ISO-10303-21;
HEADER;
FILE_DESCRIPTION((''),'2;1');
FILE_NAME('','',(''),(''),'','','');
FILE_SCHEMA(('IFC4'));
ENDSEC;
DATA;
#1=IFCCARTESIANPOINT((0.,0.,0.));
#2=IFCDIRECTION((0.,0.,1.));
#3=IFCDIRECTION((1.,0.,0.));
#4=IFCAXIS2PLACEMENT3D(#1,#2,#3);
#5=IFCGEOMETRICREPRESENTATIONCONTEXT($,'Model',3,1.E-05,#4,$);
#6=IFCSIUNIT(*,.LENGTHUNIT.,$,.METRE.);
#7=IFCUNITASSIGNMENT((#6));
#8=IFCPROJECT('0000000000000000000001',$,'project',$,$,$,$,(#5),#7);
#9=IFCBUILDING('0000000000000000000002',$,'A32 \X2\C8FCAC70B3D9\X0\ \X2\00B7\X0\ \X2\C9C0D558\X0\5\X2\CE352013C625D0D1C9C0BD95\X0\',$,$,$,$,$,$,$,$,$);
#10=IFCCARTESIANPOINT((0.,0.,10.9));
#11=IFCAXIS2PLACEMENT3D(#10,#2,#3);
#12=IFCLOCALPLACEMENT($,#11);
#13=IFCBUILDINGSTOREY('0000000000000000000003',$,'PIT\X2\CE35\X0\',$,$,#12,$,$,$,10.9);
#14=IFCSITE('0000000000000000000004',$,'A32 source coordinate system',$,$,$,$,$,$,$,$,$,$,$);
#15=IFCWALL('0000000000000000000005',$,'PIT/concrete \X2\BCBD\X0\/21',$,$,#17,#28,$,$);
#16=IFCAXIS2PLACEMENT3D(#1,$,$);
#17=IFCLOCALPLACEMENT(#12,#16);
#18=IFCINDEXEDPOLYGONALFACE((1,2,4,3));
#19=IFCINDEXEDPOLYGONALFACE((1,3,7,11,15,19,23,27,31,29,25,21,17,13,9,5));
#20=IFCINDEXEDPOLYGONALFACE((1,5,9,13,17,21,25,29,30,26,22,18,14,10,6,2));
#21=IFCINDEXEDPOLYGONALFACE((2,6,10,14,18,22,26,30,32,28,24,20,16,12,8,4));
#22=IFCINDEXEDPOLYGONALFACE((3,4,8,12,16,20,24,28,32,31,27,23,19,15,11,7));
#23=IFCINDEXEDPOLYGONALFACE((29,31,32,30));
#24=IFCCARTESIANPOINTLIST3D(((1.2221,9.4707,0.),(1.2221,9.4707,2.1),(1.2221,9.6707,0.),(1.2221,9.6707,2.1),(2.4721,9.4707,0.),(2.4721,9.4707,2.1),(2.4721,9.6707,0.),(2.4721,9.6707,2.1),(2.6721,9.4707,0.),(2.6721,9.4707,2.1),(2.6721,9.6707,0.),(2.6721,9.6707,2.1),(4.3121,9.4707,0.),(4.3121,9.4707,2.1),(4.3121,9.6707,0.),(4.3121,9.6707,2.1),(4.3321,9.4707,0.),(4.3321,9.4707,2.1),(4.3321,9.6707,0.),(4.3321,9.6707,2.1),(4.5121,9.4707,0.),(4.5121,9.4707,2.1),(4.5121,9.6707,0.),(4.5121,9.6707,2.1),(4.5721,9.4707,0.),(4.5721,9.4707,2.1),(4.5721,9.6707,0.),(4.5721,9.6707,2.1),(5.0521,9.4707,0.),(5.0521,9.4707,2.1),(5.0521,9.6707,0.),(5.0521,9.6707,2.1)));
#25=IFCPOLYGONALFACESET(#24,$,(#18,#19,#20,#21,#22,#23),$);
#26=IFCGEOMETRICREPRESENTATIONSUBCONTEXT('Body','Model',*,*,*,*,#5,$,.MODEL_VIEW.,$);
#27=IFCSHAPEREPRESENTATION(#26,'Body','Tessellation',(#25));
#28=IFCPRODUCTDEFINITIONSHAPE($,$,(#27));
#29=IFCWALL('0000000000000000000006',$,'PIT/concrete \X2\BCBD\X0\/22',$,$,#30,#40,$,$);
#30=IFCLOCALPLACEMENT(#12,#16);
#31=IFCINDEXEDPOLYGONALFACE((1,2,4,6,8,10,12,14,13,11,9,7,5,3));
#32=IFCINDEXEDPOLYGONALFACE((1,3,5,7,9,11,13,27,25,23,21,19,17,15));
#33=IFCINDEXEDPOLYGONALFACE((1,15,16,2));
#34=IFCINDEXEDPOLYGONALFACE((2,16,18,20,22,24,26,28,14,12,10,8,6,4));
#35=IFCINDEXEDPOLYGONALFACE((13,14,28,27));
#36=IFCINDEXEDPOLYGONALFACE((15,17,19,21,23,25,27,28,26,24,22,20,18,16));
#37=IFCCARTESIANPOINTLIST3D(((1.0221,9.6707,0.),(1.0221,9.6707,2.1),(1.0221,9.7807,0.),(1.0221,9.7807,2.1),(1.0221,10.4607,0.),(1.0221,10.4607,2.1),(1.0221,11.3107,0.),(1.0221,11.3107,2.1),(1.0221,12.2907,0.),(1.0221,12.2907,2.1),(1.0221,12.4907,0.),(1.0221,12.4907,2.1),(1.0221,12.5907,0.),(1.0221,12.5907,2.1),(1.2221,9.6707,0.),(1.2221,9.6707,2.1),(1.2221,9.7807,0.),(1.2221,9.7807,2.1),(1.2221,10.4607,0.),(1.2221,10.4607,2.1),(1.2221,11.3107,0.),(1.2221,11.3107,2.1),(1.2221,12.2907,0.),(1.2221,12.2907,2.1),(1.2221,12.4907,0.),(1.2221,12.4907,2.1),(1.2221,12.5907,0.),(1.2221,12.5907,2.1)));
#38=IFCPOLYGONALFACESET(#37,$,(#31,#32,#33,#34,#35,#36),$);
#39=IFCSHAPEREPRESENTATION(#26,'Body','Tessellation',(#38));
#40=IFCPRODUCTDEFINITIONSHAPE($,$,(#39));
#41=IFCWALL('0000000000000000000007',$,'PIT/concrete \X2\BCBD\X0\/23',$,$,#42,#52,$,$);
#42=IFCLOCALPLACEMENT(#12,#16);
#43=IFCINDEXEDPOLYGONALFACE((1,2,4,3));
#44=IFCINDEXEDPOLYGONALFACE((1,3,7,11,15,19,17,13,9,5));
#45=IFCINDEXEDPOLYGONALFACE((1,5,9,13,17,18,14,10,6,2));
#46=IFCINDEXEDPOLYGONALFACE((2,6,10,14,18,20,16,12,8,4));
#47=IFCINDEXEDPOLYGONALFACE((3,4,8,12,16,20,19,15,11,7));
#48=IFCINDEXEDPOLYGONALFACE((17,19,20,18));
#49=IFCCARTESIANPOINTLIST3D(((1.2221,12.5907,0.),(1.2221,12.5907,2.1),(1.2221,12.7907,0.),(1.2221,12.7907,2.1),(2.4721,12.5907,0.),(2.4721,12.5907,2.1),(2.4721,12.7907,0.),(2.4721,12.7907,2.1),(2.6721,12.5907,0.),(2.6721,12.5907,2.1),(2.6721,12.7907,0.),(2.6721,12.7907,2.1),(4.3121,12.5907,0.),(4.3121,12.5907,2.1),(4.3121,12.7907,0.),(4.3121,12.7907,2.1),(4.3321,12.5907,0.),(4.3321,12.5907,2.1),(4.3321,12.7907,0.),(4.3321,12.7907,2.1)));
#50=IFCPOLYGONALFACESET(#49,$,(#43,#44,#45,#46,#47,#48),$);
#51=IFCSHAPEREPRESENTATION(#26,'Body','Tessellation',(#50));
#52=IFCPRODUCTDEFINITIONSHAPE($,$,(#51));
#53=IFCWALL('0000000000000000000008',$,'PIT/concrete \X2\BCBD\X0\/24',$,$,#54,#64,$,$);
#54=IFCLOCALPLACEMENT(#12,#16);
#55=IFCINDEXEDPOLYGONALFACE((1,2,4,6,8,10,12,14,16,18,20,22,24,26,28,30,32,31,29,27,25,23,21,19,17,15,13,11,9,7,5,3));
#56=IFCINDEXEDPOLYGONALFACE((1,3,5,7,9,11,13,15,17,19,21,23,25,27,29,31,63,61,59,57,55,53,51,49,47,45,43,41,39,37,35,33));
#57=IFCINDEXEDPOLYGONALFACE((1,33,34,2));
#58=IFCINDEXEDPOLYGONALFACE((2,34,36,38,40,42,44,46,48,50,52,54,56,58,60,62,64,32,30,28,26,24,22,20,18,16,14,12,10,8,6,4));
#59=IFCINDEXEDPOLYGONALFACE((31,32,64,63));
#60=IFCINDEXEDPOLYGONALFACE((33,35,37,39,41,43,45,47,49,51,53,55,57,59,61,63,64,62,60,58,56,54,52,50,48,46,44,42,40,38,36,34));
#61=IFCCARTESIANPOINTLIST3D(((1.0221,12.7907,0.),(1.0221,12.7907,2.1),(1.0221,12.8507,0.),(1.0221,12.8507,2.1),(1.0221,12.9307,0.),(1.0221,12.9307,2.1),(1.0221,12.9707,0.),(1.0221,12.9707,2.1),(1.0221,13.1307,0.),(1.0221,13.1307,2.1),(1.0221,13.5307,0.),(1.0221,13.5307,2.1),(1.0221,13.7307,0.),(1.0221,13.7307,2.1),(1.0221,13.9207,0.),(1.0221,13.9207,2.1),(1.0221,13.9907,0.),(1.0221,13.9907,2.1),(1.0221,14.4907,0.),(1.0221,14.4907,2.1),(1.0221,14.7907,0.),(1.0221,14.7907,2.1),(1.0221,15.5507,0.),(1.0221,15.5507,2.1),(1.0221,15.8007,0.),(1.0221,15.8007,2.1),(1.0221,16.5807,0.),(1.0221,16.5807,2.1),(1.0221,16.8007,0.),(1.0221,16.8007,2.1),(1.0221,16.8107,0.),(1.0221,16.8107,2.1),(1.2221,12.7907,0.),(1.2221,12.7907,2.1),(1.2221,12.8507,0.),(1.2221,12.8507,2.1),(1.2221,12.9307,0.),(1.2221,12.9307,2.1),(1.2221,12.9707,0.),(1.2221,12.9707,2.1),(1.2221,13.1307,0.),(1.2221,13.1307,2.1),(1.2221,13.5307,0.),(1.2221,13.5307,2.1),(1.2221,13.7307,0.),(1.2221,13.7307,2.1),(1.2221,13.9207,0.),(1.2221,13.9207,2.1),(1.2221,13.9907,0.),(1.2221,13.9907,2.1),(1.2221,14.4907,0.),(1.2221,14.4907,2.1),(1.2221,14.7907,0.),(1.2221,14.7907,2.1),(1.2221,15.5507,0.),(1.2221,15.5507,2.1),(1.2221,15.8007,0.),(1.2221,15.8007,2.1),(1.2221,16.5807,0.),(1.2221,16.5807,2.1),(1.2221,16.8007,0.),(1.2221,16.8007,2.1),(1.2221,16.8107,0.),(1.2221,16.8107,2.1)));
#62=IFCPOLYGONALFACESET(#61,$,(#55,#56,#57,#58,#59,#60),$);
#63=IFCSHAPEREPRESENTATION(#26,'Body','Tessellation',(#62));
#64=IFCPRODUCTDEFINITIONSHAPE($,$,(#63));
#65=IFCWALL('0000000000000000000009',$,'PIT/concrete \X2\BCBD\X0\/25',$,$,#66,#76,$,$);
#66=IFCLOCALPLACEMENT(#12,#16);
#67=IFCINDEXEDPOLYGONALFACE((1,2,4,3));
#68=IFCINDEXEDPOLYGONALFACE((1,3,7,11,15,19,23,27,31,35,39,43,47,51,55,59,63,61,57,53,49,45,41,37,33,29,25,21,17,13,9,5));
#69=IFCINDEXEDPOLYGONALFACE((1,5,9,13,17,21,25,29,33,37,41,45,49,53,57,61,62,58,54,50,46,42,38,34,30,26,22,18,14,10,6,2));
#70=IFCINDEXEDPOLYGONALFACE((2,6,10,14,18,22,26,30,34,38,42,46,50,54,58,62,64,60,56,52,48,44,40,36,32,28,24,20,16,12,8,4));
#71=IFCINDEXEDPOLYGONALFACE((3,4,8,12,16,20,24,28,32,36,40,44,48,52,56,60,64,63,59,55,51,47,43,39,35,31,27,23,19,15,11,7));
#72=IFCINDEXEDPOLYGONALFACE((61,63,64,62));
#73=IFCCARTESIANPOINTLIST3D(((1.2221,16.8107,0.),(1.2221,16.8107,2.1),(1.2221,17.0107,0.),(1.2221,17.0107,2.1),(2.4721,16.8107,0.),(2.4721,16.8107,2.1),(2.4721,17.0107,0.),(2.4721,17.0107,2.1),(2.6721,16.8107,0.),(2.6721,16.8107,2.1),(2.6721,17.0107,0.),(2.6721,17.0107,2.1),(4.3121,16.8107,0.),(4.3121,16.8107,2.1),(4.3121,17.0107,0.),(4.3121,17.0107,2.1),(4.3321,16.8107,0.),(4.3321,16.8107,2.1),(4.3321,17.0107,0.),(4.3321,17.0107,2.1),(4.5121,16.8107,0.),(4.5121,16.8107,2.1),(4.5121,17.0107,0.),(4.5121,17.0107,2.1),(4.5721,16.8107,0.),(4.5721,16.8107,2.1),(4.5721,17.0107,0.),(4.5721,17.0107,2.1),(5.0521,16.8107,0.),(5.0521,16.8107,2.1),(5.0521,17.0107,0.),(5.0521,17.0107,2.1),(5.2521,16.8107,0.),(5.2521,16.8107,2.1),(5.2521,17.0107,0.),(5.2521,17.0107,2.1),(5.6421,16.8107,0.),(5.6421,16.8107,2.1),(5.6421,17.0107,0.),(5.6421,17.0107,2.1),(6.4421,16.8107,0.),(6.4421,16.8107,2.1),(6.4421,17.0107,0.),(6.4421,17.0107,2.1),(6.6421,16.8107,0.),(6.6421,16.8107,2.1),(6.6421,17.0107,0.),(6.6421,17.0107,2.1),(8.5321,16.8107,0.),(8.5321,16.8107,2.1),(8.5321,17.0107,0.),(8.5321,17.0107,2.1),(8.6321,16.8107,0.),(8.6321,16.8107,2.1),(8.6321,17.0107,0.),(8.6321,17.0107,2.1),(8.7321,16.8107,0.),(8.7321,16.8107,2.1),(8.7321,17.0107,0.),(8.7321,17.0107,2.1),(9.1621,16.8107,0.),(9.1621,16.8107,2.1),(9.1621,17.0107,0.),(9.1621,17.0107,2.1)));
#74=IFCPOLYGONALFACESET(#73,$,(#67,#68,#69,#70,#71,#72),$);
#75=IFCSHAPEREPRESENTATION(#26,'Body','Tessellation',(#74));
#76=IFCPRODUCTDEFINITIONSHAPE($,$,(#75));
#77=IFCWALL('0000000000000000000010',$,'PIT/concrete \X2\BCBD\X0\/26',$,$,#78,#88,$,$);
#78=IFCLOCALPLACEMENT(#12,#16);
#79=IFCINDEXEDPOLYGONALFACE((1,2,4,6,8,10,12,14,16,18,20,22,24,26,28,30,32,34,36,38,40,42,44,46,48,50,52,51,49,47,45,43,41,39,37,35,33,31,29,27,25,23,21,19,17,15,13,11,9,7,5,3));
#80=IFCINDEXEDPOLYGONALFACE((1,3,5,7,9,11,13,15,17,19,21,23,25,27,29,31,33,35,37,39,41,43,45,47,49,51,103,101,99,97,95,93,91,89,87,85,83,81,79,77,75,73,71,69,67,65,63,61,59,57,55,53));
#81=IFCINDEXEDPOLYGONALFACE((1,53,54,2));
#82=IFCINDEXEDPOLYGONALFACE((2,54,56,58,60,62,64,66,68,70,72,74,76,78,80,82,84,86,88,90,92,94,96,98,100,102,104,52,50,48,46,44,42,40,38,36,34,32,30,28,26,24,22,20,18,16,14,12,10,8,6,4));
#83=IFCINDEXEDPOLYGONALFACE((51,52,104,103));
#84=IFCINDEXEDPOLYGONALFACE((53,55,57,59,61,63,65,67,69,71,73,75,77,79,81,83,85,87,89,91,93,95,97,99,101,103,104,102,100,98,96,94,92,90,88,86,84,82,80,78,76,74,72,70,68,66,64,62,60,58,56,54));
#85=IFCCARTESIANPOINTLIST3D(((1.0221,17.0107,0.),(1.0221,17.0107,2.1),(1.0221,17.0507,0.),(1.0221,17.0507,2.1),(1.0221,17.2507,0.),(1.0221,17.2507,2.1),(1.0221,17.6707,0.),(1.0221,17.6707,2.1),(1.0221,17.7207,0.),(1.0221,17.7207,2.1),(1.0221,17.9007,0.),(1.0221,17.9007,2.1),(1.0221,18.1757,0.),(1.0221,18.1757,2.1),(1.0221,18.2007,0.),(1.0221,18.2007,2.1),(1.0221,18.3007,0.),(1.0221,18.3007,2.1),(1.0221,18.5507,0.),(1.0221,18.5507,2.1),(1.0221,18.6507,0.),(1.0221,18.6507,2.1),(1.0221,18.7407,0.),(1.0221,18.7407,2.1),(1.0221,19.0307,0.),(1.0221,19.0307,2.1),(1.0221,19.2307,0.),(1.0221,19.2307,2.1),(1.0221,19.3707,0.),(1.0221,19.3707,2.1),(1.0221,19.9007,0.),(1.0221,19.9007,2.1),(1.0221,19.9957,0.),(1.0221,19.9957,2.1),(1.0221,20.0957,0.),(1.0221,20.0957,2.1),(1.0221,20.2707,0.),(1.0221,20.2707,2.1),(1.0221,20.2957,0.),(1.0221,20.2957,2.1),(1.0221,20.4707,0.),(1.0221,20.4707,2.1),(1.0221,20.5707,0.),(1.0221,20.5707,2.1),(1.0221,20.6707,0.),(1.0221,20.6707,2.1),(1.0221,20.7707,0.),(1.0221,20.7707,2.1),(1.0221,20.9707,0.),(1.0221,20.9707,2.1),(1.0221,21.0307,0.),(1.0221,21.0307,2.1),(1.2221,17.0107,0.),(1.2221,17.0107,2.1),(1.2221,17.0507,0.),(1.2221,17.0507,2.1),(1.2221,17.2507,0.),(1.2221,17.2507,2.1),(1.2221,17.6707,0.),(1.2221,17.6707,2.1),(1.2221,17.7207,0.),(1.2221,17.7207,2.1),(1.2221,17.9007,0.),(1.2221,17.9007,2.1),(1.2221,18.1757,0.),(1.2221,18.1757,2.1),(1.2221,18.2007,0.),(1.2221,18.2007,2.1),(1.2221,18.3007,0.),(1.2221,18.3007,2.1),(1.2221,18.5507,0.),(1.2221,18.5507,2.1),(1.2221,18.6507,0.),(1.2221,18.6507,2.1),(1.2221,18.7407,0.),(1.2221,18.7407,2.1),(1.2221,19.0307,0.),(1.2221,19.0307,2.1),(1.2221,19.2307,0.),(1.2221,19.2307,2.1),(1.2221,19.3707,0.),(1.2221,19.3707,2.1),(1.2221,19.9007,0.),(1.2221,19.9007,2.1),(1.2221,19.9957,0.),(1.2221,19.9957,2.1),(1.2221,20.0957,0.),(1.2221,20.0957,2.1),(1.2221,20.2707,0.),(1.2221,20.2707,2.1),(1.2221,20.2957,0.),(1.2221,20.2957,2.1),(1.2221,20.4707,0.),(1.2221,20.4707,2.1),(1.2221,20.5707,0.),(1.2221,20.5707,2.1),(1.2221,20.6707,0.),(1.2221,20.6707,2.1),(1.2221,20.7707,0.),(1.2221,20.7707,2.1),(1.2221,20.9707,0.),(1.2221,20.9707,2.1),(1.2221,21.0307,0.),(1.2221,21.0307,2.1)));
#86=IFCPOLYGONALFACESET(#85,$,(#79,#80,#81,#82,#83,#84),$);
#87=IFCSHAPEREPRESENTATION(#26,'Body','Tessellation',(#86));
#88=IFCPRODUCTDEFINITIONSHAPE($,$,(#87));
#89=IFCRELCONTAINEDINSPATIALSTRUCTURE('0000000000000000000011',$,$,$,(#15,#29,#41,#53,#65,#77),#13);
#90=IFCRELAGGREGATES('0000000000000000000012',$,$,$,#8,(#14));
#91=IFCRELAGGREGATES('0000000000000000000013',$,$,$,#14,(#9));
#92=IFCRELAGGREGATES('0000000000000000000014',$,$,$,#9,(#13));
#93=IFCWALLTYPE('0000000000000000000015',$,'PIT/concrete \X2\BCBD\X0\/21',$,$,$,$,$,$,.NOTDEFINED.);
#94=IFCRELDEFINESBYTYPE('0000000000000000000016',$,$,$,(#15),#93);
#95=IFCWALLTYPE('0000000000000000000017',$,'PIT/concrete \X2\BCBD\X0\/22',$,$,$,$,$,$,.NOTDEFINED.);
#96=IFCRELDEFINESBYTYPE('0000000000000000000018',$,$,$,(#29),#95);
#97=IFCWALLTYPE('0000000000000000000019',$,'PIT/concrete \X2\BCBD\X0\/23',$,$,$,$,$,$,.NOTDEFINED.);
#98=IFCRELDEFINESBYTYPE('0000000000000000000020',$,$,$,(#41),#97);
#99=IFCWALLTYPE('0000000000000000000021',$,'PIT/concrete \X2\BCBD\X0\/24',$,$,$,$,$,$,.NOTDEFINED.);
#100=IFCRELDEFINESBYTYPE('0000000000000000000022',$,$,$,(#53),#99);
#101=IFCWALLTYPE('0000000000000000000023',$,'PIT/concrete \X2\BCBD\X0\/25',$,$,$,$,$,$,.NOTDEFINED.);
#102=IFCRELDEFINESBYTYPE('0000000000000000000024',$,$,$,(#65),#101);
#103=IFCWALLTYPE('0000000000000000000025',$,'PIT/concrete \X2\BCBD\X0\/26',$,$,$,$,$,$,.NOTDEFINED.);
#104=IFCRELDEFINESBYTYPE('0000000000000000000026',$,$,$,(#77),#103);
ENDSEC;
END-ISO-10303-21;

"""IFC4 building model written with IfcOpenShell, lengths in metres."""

from ifc_helpers import new_model, si_unit, frame, origin, origin_with_axes, place, context, subcontext, project, spatial, polyline, outline, extrude, source, transform, mapped, type_object, type_shapes, element, save


model = new_model("IFC4")

# Units and contexts
model_context = context("Model", 3, precision=1e-05, world=origin_with_axes())
body_context = subcontext(model_context, "Body", "Model", "MODEL_VIEW")
ifc_project = project(units=[si_unit("LENGTHUNIT", "METRE")], contexts=[model_context])

# Site, building, storey
site = spatial("IfcSite", under=ifc_project, Name="A32 source coordinate system")
building = spatial("IfcBuilding", under=site, Name="A32 주거동 · 지하5층–옥탑지붕")
storey_placement = place(None, frame((0.0, 0.0, 10.9), z_axis=(0.0, 0.0, 1.0), x_axis=(1.0, 0.0, 0.0)))
storey = spatial("IfcBuildingStorey", under=building, at=storey_placement, Name="PIT층", Elevation=10.9)

# Walls
wall_type_1 = type_object("IfcWallType", Name="PIT/concrete 벽/21", PredefinedType="NOTDEFINED")
shared_shape_1 = source(origin(), body_context, "Body", "SweptSolid", [
    extrude(outline(polyline([(2.6721, 9.6707), (4.3121, 9.6707), (4.3321, 9.6707), (4.5121, 9.6707), (4.5721, 9.6707), (5.0521, 9.6707), (5.0521, 9.4707), (4.5721, 9.4707), (4.5121, 9.4707), (4.3321, 9.4707), (4.3121, 9.4707), (2.6721, 9.4707), (2.4721, 9.4707), (1.2221, 9.4707), (1.2221, 9.6707), (2.4721, 9.6707), (2.6721, 9.6707)])), origin(), (0.0, 0.0, 1.0), 2.1),
])
type_shapes(wall_type_1, [shared_shape_1])
wall_1_placement = place(storey_placement, origin_with_axes())
element("IfcWall", 1, at=wall_1_placement, inside=storey, type_object=wall_type_1, Name="PIT/concrete 벽/21", context=body_context, shape_type="MappedRepresentation", body=[
    mapped(shared_shape_1, transform((0.0, 0.0, 0.0), scale=1.0)),
])
wall_type_2 = type_object("IfcWallType", Name="PIT/concrete 벽/22", PredefinedType="NOTDEFINED")
shared_shape_2 = source(origin(), body_context, "Body", "SweptSolid", [
    extrude(outline(polyline([(1.0221, 10.4607), (1.0221, 11.3107), (1.0221, 12.2907), (1.0221, 12.4907), (1.0221, 12.5907), (1.2221, 12.5907), (1.2221, 12.4907), (1.2221, 12.2907), (1.2221, 11.3107), (1.2221, 10.4607), (1.2221, 9.7807), (1.2221, 9.6707), (1.0221, 9.6707), (1.0221, 9.7807), (1.0221, 10.4607)])), origin(), (0.0, 0.0, 1.0), 2.1),
])
type_shapes(wall_type_2, [shared_shape_2])
wall_2_placement = place(storey_placement, origin_with_axes())
element("IfcWall", 2, at=wall_2_placement, inside=storey, type_object=wall_type_2, Name="PIT/concrete 벽/22", context=body_context, shape_type="MappedRepresentation", body=[
    mapped(shared_shape_2, transform((0.0, 0.0, 0.0), scale=1.0)),
])
wall_type_3 = type_object("IfcWallType", Name="PIT/concrete 벽/23", PredefinedType="NOTDEFINED")
shared_shape_3 = source(origin(), body_context, "Body", "SweptSolid", [
    extrude(outline(polyline([(2.6721, 12.7907), (4.3121, 12.7907), (4.3321, 12.7907), (4.3321, 12.5907), (4.3121, 12.5907), (2.6721, 12.5907), (2.4721, 12.5907), (1.2221, 12.5907), (1.2221, 12.7907), (2.4721, 12.7907), (2.6721, 12.7907)])), origin(), (0.0, 0.0, 1.0), 2.1),
])
type_shapes(wall_type_3, [shared_shape_3])
wall_3_placement = place(storey_placement, origin_with_axes())
element("IfcWall", 3, at=wall_3_placement, inside=storey, type_object=wall_type_3, Name="PIT/concrete 벽/23", context=body_context, shape_type="MappedRepresentation", body=[
    mapped(shared_shape_3, transform((0.0, 0.0, 0.0), scale=1.0)),
])
wall_type_4 = type_object("IfcWallType", Name="PIT/concrete 벽/24", PredefinedType="NOTDEFINED")
shared_shape_4 = source(origin(), body_context, "Body", "SweptSolid", [
    extrude(outline(polyline([(1.0221, 12.9307), (1.0221, 12.9707), (1.0221, 13.1307), (1.0221, 13.5307), (1.0221, 13.7307), (1.0221, 13.9207), (1.0221, 13.9907), (1.0221, 14.4907), (1.0221, 14.7907), (1.0221, 15.5507), (1.0221, 15.8007), (1.0221, 16.5807), (1.0221, 16.8007), (1.0221, 16.8107), (1.2221, 16.8107), (1.2221, 16.8007), (1.2221, 16.5807), (1.2221, 15.8007), (1.2221, 15.5507), (1.2221, 14.7907), (1.2221, 14.4907), (1.2221, 13.9907), (1.2221, 13.9207), (1.2221, 13.7307), (1.2221, 13.5307), (1.2221, 13.1307), (1.2221, 12.9707), (1.2221, 12.9307), (1.2221, 12.8507), (1.2221, 12.7907), (1.0221, 12.7907), (1.0221, 12.8507), (1.0221, 12.9307)])), origin(), (0.0, 0.0, 1.0), 2.1),
])
type_shapes(wall_type_4, [shared_shape_4])
wall_4_placement = place(storey_placement, origin_with_axes())
element("IfcWall", 4, at=wall_4_placement, inside=storey, type_object=wall_type_4, Name="PIT/concrete 벽/24", context=body_context, shape_type="MappedRepresentation", body=[
    mapped(shared_shape_4, transform((0.0, 0.0, 0.0), scale=1.0)),
])
wall_type_5 = type_object("IfcWallType", Name="PIT/concrete 벽/25", PredefinedType="NOTDEFINED")
shared_shape_5 = source(origin(), body_context, "Body", "SweptSolid", [
    extrude(outline(polyline([(2.6721, 17.0107), (4.3121, 17.0107), (4.3321, 17.0107), (4.5121, 17.0107), (4.5721, 17.0107), (5.0521, 17.0107), (5.2521, 17.0107), (5.6421, 17.0107), (6.4421, 17.0107), (6.6421, 17.0107), (8.5321, 17.0107), (8.6321, 17.0107), (8.7321, 17.0107), (9.1621, 17.0107), (9.1621, 16.8107), (8.7321, 16.8107), (8.6321, 16.8107), (8.5321, 16.8107), (6.6421, 16.8107), (6.4421, 16.8107), (5.6421, 16.8107), (5.2521, 16.8107), (5.0521, 16.8107), (4.5721, 16.8107), (4.5121, 16.8107), (4.3321, 16.8107), (4.3121, 16.8107), (2.6721, 16.8107), (2.4721, 16.8107), (1.2221, 16.8107), (1.2221, 17.0107), (2.4721, 17.0107), (2.6721, 17.0107)])), origin(), (0.0, 0.0, 1.0), 2.1),
])
type_shapes(wall_type_5, [shared_shape_5])
wall_5_placement = place(storey_placement, origin_with_axes())
element("IfcWall", 5, at=wall_5_placement, inside=storey, type_object=wall_type_5, Name="PIT/concrete 벽/25", context=body_context, shape_type="MappedRepresentation", body=[
    mapped(shared_shape_5, transform((0.0, 0.0, 0.0), scale=1.0)),
])
wall_type_6 = type_object("IfcWallType", Name="PIT/concrete 벽/26", PredefinedType="NOTDEFINED")
shared_shape_6 = source(origin(), body_context, "Body", "SweptSolid", [
    extrude(outline(polyline([(1.0221, 17.2507), (1.0221, 17.6707), (1.0221, 17.7207), (1.0221, 17.9007), (1.0221, 18.1757), (1.0221, 18.2007), (1.0221, 18.3007), (1.0221, 18.5507), (1.0221, 18.6507), (1.0221, 18.7407), (1.0221, 19.0307), (1.0221, 19.2307), (1.0221, 19.3707), (1.0221, 19.9007), (1.0221, 19.9957), (1.0221, 20.0957), (1.0221, 20.2707), (1.0221, 20.2957), (1.0221, 20.4707), (1.0221, 20.5707), (1.0221, 20.6707), (1.0221, 20.7707), (1.0221, 20.9707), (1.0221, 21.0307), (1.2221, 21.0307), (1.2221, 20.9707), (1.2221, 20.7707), (1.2221, 20.6707), (1.2221, 20.5707), (1.2221, 20.4707), (1.2221, 20.2957), (1.2221, 20.2707), (1.2221, 20.0957), (1.2221, 19.9957), (1.2221, 19.9007), (1.2221, 19.3707), (1.2221, 19.2307), (1.2221, 19.0307), (1.2221, 18.7407), (1.2221, 18.6507), (1.2221, 18.5507), (1.2221, 18.3007), (1.2221, 18.2007), (1.2221, 18.1757), (1.2221, 17.9007), (1.2221, 17.7207), (1.2221, 17.6707), (1.2221, 17.2507), (1.2221, 17.0507), (1.2221, 17.0107), (1.0221, 17.0107), (1.0221, 17.0507), (1.0221, 17.2507)])), origin(), (0.0, 0.0, 1.0), 2.1),
])
type_shapes(wall_type_6, [shared_shape_6])
wall_6_placement = place(storey_placement, origin_with_axes())
element("IfcWall", 6, at=wall_6_placement, inside=storey, type_object=wall_type_6, Name="PIT/concrete 벽/26", context=body_context, shape_type="MappedRepresentation", body=[
    mapped(shared_shape_6, transform((0.0, 0.0, 0.0), scale=1.0)),
])

save(model, "model.ifc")
